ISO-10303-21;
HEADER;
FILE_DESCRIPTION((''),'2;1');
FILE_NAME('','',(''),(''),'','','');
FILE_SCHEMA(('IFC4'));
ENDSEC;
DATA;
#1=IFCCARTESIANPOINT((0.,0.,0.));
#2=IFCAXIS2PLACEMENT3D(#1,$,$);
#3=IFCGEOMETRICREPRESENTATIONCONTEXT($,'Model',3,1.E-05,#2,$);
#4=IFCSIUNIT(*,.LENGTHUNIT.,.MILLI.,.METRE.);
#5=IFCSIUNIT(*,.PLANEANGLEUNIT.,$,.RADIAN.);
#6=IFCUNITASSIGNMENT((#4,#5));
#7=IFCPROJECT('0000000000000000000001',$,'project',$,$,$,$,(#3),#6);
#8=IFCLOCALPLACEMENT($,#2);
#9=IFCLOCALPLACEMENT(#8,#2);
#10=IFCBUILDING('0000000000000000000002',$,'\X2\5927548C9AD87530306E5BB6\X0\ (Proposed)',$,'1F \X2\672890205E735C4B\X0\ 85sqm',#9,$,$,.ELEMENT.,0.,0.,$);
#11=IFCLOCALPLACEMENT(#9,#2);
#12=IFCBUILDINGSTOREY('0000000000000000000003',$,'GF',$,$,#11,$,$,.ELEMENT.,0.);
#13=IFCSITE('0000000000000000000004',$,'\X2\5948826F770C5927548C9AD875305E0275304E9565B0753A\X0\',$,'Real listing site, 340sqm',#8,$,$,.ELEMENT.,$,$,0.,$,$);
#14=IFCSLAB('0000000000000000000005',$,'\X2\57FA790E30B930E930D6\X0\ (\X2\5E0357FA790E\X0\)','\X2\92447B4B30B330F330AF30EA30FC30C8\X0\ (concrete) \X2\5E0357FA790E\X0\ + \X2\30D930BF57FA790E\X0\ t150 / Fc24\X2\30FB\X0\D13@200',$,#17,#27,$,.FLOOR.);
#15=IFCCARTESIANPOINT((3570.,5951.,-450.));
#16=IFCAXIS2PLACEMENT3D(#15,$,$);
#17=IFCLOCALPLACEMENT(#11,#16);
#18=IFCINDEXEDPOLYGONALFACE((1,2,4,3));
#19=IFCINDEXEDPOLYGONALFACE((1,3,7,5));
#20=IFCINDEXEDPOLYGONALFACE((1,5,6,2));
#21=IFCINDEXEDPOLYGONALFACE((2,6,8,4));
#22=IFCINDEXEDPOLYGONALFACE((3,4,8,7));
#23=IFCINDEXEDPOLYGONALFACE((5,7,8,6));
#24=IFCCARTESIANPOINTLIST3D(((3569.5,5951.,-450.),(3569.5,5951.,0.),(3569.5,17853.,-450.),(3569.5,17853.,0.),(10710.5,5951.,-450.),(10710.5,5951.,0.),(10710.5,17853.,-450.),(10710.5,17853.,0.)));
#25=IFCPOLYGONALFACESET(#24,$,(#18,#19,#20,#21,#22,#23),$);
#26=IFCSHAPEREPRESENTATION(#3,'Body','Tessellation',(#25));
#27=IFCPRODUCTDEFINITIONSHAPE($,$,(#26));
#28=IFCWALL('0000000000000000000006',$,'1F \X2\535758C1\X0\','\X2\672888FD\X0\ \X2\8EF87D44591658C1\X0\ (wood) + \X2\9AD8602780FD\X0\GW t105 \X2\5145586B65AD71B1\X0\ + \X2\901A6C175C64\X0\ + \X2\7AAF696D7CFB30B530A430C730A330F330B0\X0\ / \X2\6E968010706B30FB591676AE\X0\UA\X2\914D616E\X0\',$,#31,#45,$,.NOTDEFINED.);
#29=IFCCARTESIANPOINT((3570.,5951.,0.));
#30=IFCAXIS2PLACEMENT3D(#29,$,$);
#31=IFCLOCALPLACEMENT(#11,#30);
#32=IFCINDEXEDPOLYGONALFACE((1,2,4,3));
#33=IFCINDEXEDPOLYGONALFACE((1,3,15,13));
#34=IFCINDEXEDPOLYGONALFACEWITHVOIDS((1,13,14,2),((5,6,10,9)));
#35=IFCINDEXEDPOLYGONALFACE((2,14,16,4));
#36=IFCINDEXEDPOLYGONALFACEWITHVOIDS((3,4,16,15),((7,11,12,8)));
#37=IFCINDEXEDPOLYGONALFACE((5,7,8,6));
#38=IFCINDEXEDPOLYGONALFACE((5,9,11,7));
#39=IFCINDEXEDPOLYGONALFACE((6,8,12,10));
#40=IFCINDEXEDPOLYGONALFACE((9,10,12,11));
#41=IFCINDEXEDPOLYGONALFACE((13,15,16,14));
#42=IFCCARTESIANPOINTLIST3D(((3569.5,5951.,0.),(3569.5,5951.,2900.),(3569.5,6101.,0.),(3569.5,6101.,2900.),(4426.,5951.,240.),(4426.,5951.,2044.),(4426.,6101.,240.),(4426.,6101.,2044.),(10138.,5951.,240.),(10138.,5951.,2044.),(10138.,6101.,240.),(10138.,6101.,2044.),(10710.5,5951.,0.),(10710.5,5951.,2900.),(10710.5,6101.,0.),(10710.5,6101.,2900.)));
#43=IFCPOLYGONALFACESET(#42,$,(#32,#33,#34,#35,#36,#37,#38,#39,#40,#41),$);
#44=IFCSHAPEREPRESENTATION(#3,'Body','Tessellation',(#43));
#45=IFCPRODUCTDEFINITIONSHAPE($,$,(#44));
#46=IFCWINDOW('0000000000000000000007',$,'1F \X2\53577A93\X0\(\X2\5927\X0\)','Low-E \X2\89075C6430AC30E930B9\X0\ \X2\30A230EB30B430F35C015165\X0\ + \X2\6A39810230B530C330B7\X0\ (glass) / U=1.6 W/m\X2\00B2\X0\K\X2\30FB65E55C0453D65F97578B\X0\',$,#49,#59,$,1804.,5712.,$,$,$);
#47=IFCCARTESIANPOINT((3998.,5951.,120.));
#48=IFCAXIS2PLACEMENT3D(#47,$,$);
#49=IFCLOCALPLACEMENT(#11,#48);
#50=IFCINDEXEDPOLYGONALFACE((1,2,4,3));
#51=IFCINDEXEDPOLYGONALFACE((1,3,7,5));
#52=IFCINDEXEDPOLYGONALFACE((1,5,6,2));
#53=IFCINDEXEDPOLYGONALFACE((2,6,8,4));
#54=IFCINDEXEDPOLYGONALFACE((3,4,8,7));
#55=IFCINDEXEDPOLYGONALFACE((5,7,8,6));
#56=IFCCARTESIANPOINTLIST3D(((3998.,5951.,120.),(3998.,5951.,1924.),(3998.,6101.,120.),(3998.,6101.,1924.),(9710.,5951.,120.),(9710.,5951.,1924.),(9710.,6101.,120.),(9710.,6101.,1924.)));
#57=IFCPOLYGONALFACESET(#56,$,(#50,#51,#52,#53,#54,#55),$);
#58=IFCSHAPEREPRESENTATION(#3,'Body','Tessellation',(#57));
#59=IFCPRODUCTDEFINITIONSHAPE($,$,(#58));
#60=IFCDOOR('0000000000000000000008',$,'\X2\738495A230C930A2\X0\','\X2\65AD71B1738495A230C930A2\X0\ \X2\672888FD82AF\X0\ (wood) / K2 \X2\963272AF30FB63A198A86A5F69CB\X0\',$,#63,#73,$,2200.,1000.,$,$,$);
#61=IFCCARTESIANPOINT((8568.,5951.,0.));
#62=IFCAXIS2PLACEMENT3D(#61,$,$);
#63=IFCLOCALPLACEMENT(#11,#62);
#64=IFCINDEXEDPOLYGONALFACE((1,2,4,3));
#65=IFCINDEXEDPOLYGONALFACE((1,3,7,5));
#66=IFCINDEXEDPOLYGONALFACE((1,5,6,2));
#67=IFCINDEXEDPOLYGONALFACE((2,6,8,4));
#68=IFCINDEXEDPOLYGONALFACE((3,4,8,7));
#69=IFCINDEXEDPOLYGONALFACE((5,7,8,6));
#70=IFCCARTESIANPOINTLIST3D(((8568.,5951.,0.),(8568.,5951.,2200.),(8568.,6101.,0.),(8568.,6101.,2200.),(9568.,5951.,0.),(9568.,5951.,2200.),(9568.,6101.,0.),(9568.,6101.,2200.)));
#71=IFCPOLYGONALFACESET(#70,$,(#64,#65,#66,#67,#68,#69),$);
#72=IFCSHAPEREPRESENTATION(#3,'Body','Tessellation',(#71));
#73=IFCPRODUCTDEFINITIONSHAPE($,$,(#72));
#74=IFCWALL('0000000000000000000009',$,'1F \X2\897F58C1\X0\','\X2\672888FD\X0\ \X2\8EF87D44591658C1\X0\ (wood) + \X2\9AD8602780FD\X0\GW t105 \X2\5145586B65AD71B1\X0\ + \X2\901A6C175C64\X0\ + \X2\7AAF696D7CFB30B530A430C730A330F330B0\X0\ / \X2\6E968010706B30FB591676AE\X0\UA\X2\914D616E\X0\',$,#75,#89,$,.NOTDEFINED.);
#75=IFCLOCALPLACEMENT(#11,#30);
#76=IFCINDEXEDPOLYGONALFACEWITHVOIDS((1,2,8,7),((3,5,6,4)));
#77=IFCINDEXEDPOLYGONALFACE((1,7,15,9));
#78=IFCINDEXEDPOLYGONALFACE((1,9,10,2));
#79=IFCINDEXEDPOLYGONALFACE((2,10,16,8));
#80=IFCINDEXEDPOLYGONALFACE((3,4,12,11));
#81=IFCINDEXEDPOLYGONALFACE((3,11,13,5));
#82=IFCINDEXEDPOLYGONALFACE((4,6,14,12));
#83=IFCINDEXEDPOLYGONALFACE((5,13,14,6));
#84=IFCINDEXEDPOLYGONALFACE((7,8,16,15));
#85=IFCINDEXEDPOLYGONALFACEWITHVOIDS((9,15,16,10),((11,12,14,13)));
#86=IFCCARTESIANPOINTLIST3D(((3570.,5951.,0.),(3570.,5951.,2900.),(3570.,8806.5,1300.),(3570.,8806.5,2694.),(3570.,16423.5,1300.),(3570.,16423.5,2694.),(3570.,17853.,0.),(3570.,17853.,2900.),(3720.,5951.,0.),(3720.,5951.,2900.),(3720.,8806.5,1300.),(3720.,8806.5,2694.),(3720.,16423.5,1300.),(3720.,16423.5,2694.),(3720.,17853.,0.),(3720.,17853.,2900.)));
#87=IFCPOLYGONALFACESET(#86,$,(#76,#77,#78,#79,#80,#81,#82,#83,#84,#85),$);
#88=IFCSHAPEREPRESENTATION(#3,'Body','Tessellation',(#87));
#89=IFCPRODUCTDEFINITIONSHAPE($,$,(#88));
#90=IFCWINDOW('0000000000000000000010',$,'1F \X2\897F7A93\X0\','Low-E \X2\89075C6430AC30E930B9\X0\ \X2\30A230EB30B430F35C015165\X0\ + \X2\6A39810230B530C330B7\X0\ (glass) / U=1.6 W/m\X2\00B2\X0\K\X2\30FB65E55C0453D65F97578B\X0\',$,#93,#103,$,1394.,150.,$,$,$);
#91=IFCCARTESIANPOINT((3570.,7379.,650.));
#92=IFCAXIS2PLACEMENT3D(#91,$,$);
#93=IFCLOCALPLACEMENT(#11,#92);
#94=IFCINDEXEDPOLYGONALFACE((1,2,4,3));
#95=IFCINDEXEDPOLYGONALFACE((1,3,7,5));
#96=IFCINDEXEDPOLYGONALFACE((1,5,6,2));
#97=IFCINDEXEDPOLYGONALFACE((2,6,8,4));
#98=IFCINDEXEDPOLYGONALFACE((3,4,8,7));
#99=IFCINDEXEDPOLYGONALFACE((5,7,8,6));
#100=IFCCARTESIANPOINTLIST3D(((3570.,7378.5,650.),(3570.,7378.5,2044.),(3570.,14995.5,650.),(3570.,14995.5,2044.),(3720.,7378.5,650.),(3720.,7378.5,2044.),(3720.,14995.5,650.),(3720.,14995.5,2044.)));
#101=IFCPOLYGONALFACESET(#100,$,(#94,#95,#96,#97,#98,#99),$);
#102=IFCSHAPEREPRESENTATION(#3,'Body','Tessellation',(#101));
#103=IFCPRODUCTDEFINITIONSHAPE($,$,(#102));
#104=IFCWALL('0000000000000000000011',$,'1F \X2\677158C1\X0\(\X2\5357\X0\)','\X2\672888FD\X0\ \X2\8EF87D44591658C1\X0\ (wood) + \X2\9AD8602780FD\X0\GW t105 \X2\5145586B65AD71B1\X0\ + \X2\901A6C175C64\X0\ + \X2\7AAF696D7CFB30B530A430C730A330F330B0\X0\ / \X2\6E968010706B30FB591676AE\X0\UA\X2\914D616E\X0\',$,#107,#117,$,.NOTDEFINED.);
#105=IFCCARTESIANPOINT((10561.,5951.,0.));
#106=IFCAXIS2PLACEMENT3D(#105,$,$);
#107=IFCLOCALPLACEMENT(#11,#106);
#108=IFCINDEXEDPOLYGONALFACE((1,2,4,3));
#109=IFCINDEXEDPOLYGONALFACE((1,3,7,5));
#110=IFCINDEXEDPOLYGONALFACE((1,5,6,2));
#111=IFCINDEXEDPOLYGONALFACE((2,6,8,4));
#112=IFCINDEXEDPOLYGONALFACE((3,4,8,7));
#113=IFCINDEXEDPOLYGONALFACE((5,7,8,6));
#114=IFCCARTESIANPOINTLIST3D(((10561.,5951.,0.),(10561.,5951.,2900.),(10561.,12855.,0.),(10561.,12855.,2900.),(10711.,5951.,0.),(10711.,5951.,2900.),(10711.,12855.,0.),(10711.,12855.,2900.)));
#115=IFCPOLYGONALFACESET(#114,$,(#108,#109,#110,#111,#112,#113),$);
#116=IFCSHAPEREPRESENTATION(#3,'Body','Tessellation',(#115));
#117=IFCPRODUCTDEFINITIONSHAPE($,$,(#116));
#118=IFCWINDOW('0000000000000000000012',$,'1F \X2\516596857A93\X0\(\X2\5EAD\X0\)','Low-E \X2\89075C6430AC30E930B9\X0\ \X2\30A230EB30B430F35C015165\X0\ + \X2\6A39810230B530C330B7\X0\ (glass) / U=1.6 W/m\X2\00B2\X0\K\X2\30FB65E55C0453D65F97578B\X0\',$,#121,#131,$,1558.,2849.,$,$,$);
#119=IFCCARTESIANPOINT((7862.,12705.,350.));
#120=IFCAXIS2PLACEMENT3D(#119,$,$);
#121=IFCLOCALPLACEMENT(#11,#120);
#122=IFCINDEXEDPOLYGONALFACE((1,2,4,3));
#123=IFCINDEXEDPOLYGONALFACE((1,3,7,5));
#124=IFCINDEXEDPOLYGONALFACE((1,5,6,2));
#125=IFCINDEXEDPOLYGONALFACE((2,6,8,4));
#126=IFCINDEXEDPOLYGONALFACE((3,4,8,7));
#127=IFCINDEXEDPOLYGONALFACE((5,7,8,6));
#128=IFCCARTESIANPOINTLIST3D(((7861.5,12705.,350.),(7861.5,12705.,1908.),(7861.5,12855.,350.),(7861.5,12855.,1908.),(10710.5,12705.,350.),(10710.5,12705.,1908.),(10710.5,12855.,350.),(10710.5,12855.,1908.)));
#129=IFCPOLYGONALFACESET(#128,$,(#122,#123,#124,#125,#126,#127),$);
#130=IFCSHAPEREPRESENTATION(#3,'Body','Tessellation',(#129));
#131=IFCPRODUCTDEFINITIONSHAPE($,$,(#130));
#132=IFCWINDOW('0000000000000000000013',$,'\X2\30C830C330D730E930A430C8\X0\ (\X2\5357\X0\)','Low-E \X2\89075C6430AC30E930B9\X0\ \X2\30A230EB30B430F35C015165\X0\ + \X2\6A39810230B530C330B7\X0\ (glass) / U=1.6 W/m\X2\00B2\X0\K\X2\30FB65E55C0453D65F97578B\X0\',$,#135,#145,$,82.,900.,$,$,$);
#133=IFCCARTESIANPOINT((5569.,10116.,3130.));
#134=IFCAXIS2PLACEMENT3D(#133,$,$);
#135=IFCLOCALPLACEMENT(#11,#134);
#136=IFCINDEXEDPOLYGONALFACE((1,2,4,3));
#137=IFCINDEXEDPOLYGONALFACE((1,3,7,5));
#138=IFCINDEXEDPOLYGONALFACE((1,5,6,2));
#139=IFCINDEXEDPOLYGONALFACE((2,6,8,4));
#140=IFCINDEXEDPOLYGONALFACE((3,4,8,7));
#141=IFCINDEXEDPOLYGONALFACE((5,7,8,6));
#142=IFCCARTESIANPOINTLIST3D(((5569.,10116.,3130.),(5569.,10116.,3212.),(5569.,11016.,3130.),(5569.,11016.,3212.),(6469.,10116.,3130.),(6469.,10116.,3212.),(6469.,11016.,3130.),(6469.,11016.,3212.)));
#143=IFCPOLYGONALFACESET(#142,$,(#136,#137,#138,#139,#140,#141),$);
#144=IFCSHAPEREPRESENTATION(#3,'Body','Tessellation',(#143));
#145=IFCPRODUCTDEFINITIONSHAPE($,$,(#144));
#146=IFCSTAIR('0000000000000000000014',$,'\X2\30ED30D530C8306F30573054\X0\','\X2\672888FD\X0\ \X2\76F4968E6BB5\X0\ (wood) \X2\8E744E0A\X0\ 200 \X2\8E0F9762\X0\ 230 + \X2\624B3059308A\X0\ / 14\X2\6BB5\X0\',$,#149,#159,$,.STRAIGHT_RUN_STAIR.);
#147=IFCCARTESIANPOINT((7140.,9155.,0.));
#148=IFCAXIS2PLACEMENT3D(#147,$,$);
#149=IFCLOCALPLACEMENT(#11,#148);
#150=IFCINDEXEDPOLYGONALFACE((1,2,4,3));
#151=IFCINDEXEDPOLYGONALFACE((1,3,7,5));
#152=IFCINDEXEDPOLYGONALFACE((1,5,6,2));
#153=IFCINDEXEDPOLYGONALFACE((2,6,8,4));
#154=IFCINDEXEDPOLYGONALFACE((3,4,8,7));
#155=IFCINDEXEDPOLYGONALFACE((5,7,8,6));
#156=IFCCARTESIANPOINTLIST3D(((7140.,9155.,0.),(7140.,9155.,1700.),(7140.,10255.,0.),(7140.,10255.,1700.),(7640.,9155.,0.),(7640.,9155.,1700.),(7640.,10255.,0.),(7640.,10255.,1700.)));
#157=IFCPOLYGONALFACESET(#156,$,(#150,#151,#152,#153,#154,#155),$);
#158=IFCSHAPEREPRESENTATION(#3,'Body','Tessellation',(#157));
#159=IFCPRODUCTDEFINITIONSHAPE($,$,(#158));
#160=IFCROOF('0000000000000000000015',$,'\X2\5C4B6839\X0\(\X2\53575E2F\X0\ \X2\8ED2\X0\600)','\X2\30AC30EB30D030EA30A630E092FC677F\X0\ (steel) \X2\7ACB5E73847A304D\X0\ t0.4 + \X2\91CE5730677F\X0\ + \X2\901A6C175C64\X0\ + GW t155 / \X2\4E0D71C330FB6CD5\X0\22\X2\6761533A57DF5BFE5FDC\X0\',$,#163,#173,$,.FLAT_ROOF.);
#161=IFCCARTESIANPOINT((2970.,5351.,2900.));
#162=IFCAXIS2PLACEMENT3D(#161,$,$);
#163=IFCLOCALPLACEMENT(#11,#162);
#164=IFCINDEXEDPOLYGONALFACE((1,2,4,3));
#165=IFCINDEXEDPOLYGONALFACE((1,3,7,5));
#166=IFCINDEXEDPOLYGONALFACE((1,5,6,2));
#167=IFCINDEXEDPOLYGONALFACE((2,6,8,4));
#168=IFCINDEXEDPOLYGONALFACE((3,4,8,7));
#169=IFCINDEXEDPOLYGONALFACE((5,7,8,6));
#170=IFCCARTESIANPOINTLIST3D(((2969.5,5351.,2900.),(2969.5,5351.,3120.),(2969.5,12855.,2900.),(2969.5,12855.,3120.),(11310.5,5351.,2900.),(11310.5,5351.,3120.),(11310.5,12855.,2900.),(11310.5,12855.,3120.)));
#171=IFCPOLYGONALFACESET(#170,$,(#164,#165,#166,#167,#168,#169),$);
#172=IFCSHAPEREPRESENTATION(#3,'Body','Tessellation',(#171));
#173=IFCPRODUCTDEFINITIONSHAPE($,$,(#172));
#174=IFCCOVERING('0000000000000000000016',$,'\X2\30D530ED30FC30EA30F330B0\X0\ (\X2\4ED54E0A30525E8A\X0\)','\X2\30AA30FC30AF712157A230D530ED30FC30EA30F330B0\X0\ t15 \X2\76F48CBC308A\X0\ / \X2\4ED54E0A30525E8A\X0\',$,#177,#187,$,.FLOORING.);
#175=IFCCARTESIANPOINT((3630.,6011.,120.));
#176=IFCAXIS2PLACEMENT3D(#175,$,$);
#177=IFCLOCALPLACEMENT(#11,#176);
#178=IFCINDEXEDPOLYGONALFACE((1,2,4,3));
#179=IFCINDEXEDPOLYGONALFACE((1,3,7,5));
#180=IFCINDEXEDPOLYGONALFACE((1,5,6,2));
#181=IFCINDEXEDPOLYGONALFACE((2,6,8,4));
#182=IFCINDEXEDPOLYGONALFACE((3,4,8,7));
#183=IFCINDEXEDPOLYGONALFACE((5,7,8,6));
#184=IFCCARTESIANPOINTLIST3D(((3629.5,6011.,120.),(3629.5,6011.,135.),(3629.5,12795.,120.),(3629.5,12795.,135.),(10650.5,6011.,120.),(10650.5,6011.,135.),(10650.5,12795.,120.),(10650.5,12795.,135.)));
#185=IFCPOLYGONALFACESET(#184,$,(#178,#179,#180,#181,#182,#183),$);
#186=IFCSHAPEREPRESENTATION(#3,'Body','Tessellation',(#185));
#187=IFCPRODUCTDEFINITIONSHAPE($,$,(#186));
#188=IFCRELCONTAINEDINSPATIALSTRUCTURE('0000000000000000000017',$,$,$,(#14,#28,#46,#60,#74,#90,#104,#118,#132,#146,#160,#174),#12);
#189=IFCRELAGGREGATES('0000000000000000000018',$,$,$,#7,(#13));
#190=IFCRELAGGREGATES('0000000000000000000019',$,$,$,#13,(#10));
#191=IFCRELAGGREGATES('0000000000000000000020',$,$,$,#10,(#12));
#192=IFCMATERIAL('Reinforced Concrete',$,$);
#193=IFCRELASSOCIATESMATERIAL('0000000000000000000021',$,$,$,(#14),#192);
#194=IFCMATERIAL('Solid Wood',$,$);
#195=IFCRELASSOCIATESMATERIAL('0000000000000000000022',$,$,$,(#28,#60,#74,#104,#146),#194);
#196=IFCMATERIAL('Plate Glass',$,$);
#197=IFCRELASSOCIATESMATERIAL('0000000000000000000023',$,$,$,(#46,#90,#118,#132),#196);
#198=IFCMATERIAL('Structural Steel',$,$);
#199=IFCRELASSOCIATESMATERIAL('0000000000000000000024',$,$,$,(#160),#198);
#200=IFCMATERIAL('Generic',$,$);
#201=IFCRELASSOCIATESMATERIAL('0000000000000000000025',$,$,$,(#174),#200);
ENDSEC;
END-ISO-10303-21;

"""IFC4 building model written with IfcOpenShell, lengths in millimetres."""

from ifc_helpers import new_model, si_unit, frame, frame_2d, origin, place, context, project, spatial, rectangle, extrude, material, element, fill, save


model = new_model("IFC4")

# Units and contexts
model_context = context("Model", 3, precision=1e-05, world=origin())
ifc_project = project(units=[si_unit("LENGTHUNIT", "METRE", prefix="MILLI"), si_unit("PLANEANGLEUNIT", "RADIAN")], contexts=[model_context])

# Site, building, storey
site_placement = place(None, origin())
site = spatial("IfcSite", under=ifc_project, at=site_placement, Name="奈良県大和高田市田井新町", ObjectType="Real listing site, 340sqm", CompositionType="ELEMENT", RefElevation=0.0)
building_placement = place(site_placement, origin())
building = spatial("IfcBuilding", under=site, at=building_placement, Name="大和高田の家 (Proposed)", ObjectType="1F 木造平屋 85sqm", CompositionType="ELEMENT", ElevationOfRefHeight=0.0, ElevationOfTerrain=0.0)
storey_placement = place(building_placement, origin())
storey = spatial("IfcBuildingStorey", under=building, at=storey_placement, Name="GF", CompositionType="ELEMENT", Elevation=0.0)

# Slab
ifc_material_1 = material(Name="Reinforced Concrete")
slab_1_placement = place(storey_placement, frame((3570.0, 5951.0, -450.0)))
element("IfcSlab", 1, at=slab_1_placement, inside=storey, material=ifc_material_1, Name="基礎スラブ (布基礎)", Description="鉄筋コンクリート (concrete) 布基礎 + ベタ基礎 t150 / Fc24・D13@200", PredefinedType="FLOOR", context=model_context, shape_type="SweptSolid", body=[
    extrude(rectangle(XDim=7141.0, YDim=11902.0, at=frame_2d((3570.0, 5951.0))), frame((3570.0, 5951.0, -450.0)), (0.0, 0.0, 1.0), 450.0),
])
ifc_material_2 = material(Name="Solid Wood")

# Wall, openings, window, door
wall_1_placement = place(storey_placement, frame((3570.0, 5951.0, 0.0)))
wall_1 = element("IfcWall", 2, at=wall_1_placement, inside=storey, material=ifc_material_2, Name="1F 南壁", Description="木製 軸組外壁 (wood) + 高性能GW t105 充填断熱 + 通気層 + 窯業系サイディング / 準耐火・外皮UA配慮", PredefinedType="NOTDEFINED", context=model_context, shape_type="SweptSolid", body=[
    extrude(rectangle(XDim=7141.0, YDim=150.0, at=frame_2d((3570.0, 75.0))), frame((3570.0, 5951.0, 0.0)), (0.0, 0.0, 1.0), 2900.0),
])
opening_1_placement = place(storey_placement, frame((3998.0, 5951.0, 120.0)))
opening_1 = element("IfcOpeningElement", 3, at=opening_1_placement, cuts=wall_1, PredefinedType="NOTDEFINED", context=model_context, shape_type="SweptSolid", body=[
    extrude(rectangle(XDim=5712.0, YDim=150.0, at=frame_2d((2856.0, 75.0))), frame((3998.0, 5951.0, 120.0)), (0.0, 0.0, 1.0), 1804.0),
])
opening_2_placement = place(storey_placement, frame((8568.0, 5951.0, 0.0)))
opening_2 = element("IfcOpeningElement", 4, at=opening_2_placement, cuts=wall_1, PredefinedType="NOTDEFINED", context=model_context, shape_type="SweptSolid", body=[
    extrude(rectangle(XDim=1000.0, YDim=150.0, at=frame_2d((500.0, 75.0))), frame((8568.0, 5951.0, 0.0)), (0.0, 0.0, 1.0), 2200.0),
])
ifc_material_3 = material(Name="Plate Glass")
window_1_placement = place(storey_placement, frame((3998.0, 5951.0, 120.0)))
window_1 = element("IfcWindow", 5, at=window_1_placement, inside=storey, material=ifc_material_3, Name="1F 南窓(大)", Description="Low-E 複層ガラス アルゴン封入 + 樹脂サッシ (glass) / U=1.6 W/m²K・日射取得型", OverallHeight=1804.0, OverallWidth=5712.0, context=model_context, shape_type="SweptSolid", body=[
    extrude(rectangle(XDim=5712.0, YDim=150.0, at=frame_2d((2856.0, 75.0))), frame((3998.0, 5951.0, 120.0)), (0.0, 0.0, 1.0), 1804.0),
])
fill(opening_1, window_1)
door_1_placement = place(storey_placement, frame((8568.0, 5951.0, 0.0)))
door_1 = element("IfcDoor", 6, at=door_1_placement, inside=storey, material=ifc_material_2, Name="玄関ドア", Description="断熱玄関ドア 木製芯 (wood) / K2 防犯・採風機構", OverallHeight=2200.0, OverallWidth=1000.0, context=model_context, shape_type="SweptSolid", body=[
    extrude(rectangle(XDim=1000.0, YDim=150.0, at=frame_2d((500.0, 75.0))), frame((8568.0, 5951.0, 0.0)), (0.0, 0.0, 1.0), 2200.0),
])
fill(opening_2, door_1)

# Walls, openings, windows
wall_2_placement = place(storey_placement, frame((3570.0, 5951.0, 0.0)))
wall_2 = element("IfcWall", 7, at=wall_2_placement, inside=storey, material=ifc_material_2, Name="1F 西壁", Description="木製 軸組外壁 (wood) + 高性能GW t105 充填断熱 + 通気層 + 窯業系サイディング / 準耐火・外皮UA配慮", PredefinedType="NOTDEFINED", context=model_context, shape_type="SweptSolid", body=[
    extrude(rectangle(XDim=150.0, YDim=11902.0, at=frame_2d((75.0, 5951.0))), frame((3570.0, 5951.0, 0.0)), (0.0, 0.0, 1.0), 2900.0),
])
opening_3_placement = place(storey_placement, frame((3570.0, 7379.0, 650.0)))
opening_3 = element("IfcOpeningElement", 8, at=opening_3_placement, cuts=wall_2, PredefinedType="NOTDEFINED", context=model_context, shape_type="SweptSolid", body=[
    extrude(rectangle(XDim=150.0, YDim=7617.0, at=frame_2d((75.0, 3808.0))), frame((3570.0, 7379.0, 650.0)), (0.0, 0.0, 1.0), 1394.0),
])
window_2_placement = place(storey_placement, frame((3570.0, 7379.0, 650.0)))
window_2 = element("IfcWindow", 9, at=window_2_placement, inside=storey, material=ifc_material_3, Name="1F 西窓", Description="Low-E 複層ガラス アルゴン封入 + 樹脂サッシ (glass) / U=1.6 W/m²K・日射取得型", OverallHeight=1394.0, OverallWidth=150.0, context=model_context, shape_type="SweptSolid", body=[
    extrude(rectangle(XDim=150.0, YDim=7617.0, at=frame_2d((75.0, 3808.0))), frame((3570.0, 7379.0, 650.0)), (0.0, 0.0, 1.0), 1394.0),
])
fill(opening_3, window_2)
wall_3_placement = place(storey_placement, frame((10561.0, 5951.0, 0.0)))
wall_3 = element("IfcWall", 10, at=wall_3_placement, inside=storey, material=ifc_material_2, Name="1F 東壁(南)", Description="木製 軸組外壁 (wood) + 高性能GW t105 充填断熱 + 通気層 + 窯業系サイディング / 準耐火・外皮UA配慮", PredefinedType="NOTDEFINED", context=model_context, shape_type="SweptSolid", body=[
    extrude(rectangle(XDim=150.0, YDim=6904.0, at=frame_2d((75.0, 3452.0))), frame((10561.0, 5951.0, 0.0)), (0.0, 0.0, 1.0), 2900.0),
])
opening_4_placement = place(storey_placement, frame((7862.0, 12705.0, 350.0)))
opening_4 = element("IfcOpeningElement", 11, at=opening_4_placement, cuts=wall_3, PredefinedType="NOTDEFINED", context=model_context, shape_type="SweptSolid", body=[
    extrude(rectangle(XDim=2849.0, YDim=150.0, at=frame_2d((1424.0, 75.0))), frame((7862.0, 12705.0, 350.0)), (0.0, 0.0, 1.0), 1558.0),
])
window_3_placement = place(storey_placement, frame((7862.0, 12705.0, 350.0)))
window_3 = element("IfcWindow", 12, at=window_3_placement, inside=storey, material=ifc_material_3, Name="1F 入隅窓(庭)", Description="Low-E 複層ガラス アルゴン封入 + 樹脂サッシ (glass) / U=1.6 W/m²K・日射取得型", OverallHeight=1558.0, OverallWidth=2849.0, context=model_context, shape_type="SweptSolid", body=[
    extrude(rectangle(XDim=2849.0, YDim=150.0, at=frame_2d((1424.0, 75.0))), frame((7862.0, 12705.0, 350.0)), (0.0, 0.0, 1.0), 1558.0),
])
fill(opening_4, window_3)

# Window
window_4_placement = place(storey_placement, frame((5569.0, 10116.0, 3130.0)))
element("IfcWindow", 13, at=window_4_placement, inside=storey, material=ifc_material_3, Name="トップライト (南)", Description="Low-E 複層ガラス アルゴン封入 + 樹脂サッシ (glass) / U=1.6 W/m²K・日射取得型", OverallHeight=82.0, OverallWidth=900.0, context=model_context, shape_type="SweptSolid", body=[
    extrude(rectangle(XDim=900.0, YDim=900.0, at=frame_2d((450.0, 450.0))), frame((5569.0, 10116.0, 3130.0)), (0.0, 0.0, 1.0), 82.0),
])

# Stair
stair_placement = place(storey_placement, frame((7140.0, 9155.0, 0.0)))
element("IfcStair", 14, at=stair_placement, inside=storey, material=ifc_material_2, Name="ロフトはしご", Description="木製 直階段 (wood) 蹴上 200 踏面 230 + 手すり / 14段", PredefinedType="STRAIGHT_RUN_STAIR", context=model_context, shape_type="SweptSolid", body=[
    extrude(rectangle(XDim=500.0, YDim=1100.0, at=frame_2d((250.0, 550.0))), frame((7140.0, 9155.0, 0.0)), (0.0, 0.0, 1.0), 1700.0),
])

# Roof
ifc_material_4 = material(Name="Structural Steel")
roof_placement = place(storey_placement, frame((2970.0, 5351.0, 2900.0)))
element("IfcRoof", 15, at=roof_placement, inside=storey, material=ifc_material_4, Name="屋根(南帯 軒600)", Description="ガルバリウム鋼板 (steel) 立平葺き t0.4 + 野地板 + 通気層 + GW t155 / 不燃・法22条区域対応", PredefinedType="FLAT_ROOF", context=model_context, shape_type="SweptSolid", body=[
    extrude(rectangle(XDim=8341.0, YDim=7504.0, at=frame_2d((4170.0, 3752.0))), frame((2970.0, 5351.0, 2900.0)), (0.0, 0.0, 1.0), 220.0),
])

# Covering
ifc_material_5 = material(Name="Generic")
covering_placement = place(storey_placement, frame((3630.0, 6011.0, 120.0)))
element("IfcCovering", 16, at=covering_placement, inside=storey, material=ifc_material_5, Name="フローリング (仕上げ床)", Description="オーク無垢フローリング t15 直貼り / 仕上げ床", PredefinedType="FLOORING", context=model_context, shape_type="SweptSolid", body=[
    extrude(rectangle(XDim=7021.0, YDim=6784.0, at=frame_2d((3510.0, 3392.0))), frame((3630.0, 6011.0, 120.0)), (0.0, 0.0, 1.0), 15.0),
])

save(model, "model.ifc")
